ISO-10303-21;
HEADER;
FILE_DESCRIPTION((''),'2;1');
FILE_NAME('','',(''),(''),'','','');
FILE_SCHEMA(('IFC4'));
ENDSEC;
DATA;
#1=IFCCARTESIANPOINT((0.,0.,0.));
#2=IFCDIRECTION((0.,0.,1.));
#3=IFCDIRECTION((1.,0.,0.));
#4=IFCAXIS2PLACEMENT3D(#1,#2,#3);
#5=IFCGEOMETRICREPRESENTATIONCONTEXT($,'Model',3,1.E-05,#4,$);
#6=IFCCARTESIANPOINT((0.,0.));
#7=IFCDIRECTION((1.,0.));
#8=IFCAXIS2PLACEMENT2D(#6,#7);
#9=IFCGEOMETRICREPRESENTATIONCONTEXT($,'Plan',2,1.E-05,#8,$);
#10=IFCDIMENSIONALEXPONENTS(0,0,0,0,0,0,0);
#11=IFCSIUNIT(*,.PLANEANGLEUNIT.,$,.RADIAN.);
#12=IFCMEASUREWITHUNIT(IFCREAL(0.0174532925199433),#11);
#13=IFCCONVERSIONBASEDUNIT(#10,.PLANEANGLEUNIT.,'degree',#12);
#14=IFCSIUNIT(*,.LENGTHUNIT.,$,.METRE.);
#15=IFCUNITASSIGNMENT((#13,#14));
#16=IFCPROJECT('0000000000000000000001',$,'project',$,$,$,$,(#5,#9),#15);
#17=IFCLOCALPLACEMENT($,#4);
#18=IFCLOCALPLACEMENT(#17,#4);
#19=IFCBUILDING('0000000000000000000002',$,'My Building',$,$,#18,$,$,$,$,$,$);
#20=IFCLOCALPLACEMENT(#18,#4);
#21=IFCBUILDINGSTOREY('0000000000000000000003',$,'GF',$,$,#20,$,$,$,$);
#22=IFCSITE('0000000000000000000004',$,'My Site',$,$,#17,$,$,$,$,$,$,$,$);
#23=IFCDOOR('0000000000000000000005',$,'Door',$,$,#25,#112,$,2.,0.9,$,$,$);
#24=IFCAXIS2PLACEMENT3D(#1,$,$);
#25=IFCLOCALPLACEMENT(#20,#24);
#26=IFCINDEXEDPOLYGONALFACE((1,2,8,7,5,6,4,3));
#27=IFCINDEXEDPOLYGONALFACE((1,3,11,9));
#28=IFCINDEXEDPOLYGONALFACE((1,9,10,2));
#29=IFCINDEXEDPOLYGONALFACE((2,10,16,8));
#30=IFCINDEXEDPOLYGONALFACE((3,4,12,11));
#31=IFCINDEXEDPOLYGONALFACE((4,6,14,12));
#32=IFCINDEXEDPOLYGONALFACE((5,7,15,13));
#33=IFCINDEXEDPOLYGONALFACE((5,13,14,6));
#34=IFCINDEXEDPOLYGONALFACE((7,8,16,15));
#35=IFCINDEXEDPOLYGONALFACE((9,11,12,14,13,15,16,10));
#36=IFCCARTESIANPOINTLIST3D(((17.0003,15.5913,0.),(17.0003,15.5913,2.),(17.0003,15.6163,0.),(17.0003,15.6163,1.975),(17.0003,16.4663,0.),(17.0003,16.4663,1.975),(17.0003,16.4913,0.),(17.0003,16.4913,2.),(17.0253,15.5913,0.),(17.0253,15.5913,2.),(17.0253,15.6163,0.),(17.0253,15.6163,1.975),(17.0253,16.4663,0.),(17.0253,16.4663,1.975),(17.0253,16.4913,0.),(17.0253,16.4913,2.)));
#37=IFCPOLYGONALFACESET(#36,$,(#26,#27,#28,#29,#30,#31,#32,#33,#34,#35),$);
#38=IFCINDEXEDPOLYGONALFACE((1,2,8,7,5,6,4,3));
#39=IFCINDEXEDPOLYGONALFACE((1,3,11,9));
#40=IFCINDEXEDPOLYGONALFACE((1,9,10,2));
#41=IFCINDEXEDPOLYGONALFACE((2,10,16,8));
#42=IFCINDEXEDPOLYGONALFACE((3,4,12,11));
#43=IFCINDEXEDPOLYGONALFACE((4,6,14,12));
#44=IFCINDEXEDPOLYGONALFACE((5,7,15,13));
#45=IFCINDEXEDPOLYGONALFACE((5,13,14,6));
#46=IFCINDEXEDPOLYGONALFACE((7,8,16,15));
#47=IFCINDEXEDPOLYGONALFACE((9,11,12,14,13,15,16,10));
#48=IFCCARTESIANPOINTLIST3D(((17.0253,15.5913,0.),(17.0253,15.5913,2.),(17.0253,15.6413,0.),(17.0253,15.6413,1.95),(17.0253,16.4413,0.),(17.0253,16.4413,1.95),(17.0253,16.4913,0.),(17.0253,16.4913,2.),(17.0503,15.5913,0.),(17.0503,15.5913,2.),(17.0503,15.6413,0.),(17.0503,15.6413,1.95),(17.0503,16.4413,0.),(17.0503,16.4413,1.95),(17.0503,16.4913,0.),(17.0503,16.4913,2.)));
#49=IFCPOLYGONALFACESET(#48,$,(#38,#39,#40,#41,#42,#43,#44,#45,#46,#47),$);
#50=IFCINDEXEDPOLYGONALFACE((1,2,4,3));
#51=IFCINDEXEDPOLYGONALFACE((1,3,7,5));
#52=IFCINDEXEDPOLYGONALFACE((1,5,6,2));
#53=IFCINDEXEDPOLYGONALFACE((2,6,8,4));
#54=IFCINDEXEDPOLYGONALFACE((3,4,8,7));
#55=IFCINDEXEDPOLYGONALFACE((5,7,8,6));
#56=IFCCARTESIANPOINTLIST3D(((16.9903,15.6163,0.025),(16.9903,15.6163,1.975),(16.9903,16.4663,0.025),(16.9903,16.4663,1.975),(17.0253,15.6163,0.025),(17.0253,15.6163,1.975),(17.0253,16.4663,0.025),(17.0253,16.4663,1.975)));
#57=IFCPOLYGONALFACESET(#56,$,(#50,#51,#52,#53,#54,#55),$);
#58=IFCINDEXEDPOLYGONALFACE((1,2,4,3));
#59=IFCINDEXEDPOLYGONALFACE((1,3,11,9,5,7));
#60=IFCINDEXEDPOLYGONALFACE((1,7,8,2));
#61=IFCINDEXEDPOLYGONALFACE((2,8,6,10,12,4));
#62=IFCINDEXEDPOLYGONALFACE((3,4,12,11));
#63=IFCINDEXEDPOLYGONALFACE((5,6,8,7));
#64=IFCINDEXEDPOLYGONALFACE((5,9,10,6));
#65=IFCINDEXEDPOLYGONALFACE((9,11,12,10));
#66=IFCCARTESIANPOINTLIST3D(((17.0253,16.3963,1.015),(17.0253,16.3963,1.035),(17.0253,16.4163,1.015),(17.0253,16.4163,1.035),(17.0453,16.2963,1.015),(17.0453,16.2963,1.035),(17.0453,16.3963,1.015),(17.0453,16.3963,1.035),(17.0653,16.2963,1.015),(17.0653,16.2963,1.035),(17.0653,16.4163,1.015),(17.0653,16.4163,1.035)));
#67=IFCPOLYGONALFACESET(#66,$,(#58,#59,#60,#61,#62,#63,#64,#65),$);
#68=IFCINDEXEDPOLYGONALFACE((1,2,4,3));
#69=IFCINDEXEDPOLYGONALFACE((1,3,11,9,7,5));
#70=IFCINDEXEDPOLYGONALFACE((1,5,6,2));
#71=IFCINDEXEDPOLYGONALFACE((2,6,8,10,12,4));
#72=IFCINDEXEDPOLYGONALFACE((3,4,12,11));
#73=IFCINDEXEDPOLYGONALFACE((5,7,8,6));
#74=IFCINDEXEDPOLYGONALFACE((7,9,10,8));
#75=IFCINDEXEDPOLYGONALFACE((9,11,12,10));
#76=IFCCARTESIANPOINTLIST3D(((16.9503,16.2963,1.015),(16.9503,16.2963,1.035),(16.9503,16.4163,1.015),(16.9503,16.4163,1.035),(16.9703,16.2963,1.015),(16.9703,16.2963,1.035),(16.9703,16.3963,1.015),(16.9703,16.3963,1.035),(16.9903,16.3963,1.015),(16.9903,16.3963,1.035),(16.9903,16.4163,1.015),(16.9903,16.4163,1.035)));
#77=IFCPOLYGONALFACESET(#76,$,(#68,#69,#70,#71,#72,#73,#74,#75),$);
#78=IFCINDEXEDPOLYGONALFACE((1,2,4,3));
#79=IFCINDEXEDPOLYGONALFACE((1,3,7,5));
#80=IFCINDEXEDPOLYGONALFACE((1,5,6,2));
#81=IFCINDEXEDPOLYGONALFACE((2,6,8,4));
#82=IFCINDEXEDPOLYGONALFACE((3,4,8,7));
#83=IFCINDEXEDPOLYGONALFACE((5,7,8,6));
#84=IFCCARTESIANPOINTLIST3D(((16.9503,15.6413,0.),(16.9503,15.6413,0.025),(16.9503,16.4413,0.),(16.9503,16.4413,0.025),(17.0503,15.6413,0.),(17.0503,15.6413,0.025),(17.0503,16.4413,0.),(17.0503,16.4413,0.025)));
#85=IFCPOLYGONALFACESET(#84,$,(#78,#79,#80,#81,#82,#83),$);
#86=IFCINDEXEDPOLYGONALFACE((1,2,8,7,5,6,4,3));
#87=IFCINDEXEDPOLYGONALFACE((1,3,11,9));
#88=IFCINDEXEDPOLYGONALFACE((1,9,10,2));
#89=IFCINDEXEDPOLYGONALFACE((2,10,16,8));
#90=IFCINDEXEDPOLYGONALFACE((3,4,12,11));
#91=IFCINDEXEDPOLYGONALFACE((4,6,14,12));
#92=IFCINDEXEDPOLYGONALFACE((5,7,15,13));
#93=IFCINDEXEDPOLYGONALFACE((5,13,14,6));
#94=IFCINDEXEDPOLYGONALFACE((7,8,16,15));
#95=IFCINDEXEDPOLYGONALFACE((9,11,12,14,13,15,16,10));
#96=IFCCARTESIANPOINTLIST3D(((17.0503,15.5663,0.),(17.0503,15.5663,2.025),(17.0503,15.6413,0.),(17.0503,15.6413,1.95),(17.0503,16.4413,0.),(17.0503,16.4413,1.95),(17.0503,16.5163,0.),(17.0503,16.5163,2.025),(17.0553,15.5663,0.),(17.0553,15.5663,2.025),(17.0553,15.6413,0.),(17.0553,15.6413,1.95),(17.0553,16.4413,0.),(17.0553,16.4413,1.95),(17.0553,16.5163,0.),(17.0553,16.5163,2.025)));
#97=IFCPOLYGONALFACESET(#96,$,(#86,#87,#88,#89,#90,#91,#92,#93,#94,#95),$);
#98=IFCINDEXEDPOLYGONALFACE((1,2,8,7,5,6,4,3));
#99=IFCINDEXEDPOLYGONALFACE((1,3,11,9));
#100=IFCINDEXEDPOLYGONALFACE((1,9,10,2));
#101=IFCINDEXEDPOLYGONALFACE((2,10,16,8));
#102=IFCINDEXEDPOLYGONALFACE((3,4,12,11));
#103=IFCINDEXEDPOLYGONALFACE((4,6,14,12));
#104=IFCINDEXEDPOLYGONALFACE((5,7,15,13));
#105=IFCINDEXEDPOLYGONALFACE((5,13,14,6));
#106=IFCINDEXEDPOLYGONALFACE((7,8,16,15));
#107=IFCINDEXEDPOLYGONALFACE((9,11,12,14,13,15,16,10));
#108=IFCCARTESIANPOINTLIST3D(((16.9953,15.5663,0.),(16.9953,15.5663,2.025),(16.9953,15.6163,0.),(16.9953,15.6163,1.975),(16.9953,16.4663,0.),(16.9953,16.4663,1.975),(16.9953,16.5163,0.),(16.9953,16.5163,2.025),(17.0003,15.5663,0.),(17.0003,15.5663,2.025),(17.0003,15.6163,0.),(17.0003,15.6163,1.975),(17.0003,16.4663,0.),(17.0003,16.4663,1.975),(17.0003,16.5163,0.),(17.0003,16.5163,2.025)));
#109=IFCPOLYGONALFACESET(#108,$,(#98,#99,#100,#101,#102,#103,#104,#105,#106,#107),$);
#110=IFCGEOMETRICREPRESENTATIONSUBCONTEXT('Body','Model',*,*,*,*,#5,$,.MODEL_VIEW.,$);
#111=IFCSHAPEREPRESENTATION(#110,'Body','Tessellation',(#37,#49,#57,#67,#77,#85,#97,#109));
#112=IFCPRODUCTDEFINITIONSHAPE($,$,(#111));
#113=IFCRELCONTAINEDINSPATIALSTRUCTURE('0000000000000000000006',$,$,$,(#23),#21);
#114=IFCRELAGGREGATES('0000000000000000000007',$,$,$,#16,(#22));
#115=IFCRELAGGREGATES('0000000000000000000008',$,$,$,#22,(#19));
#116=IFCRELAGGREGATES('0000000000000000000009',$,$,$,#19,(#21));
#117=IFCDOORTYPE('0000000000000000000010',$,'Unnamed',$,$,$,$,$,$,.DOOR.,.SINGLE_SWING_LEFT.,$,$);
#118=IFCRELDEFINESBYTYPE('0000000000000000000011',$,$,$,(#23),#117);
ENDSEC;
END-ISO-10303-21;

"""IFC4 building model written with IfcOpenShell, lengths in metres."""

from ifc_helpers import new_model, entity, si_unit, converted_unit, frame, origin_with_axes, origin_2d_with_axis, place, context, subcontext, project, spatial, line, indexed_curve, outline, extrude, shape, source, transform, mapped, type_object, type_shapes, element, save


model = new_model("IFC4")

# Units and contexts
model_context = context("Model", 3, precision=1e-05, world=origin_with_axes())
plan_context = context("Plan", 2, precision=1e-05, world=origin_2d_with_axis())
body_context_1 = subcontext(model_context, "Body", "Model", "MODEL_VIEW")
body_context_2 = subcontext(plan_context, "Body", "Plan", "PLAN_VIEW")
ifc_project = project(units=[converted_unit("PLANEANGLEUNIT", "degree", entity("IfcReal", 0.0174532925199433), si_unit("PLANEANGLEUNIT", "RADIAN"), dimensions=[0, 0, 0, 0, 0, 0, 0]), si_unit("LENGTHUNIT", "METRE")], contexts=[model_context, plan_context])

# Site, building, storey
site_placement = place(None, origin_with_axes())
site = spatial("IfcSite", under=ifc_project, at=site_placement, Name="My Site")
building_placement = place(site_placement, origin_with_axes())
building = spatial("IfcBuilding", under=site, at=building_placement, Name="My Building")
storey_placement = place(building_placement, origin_with_axes())
storey = spatial("IfcBuildingStorey", under=building, at=storey_placement, Name="GF")

# Shared definitions
door_type = type_object("IfcDoorType", Name="Unnamed", OperationType="SINGLE_SWING_LEFT", PredefinedType="DOOR")
shared_shape_1 = source(origin_with_axes(), body_context_1, "Body", "SweptSolid", [
    extrude(outline(indexed_curve([(0.0, 0.0), (0.0, 2.0), (0.9, 2.0), (0.9, 0.0), (0.875, 0.0), (0.875, 1.975), (0.025, 1.975), (0.025, 0.0)], segments=[line(1, 2, 3, 4, 5, 6, 7, 8, 1)])), frame((0.0, 0.025, 0.0), z_axis=(0.0, -1.0, 0.0), x_axis=(1.0, 0.0, 0.0)), (0.0, 0.0, -1.0), 0.025),
    extrude(outline(indexed_curve([(0.0, 0.0), (0.0, 2.0), (0.9, 2.0), (0.9, 0.0), (0.85, 0.0), (0.85, 1.95), (0.05, 1.95), (0.05, 0.0)], segments=[line(1, 2, 3, 4, 5, 6, 7, 8, 1)])), frame((0.0, 0.0, 0.0), z_axis=(0.0, -1.0, 0.0), x_axis=(1.0, 0.0, 0.0)), (0.0, 0.0, -1.0), 0.025),
    extrude(outline(indexed_curve([(0.0, 0.0), (0.85, 0.0), (0.85, 0.035), (0.0, 0.035)], segments=[line(1, 2, 3, 4, 1)])), frame((0.025, 0.025, 0.025), z_axis=(0.0, 0.0, 1.0), x_axis=(1.0, 0.0, 0.0)), (0.0, 0.0, 1.0), 1.95),
    extrude(outline(indexed_curve([(0.0, 0.0), (0.0, -0.04), (-0.12, -0.04), (-0.12, -0.02), (-0.02, -0.02), (-0.02, 0.0)], segments=[line(1, 2, 3, 4, 5, 6, 1)])), frame((0.825, 0.025, 1.015), z_axis=(0.0, 0.0, 1.0), x_axis=(1.0, 0.0, 0.0)), (0.0, 0.0, 1.0), 0.02),
    extrude(outline(indexed_curve([(0.0, 0.0), (0.0, 0.04), (-0.12, 0.04), (-0.12, 0.02), (-0.02, 0.02), (-0.02, 0.0)], segments=[line(1, 2, 3, 4, 5, 6, 1)])), frame((0.825, 0.06, 1.015), z_axis=(0.0, 0.0, 1.0), x_axis=(1.0, 0.0, 0.0)), (0.0, 0.0, 1.0), 0.02),
    extrude(outline(indexed_curve([(0.0, 0.0), (0.8, 0.0), (0.8, 0.1), (0.0, 0.1)], segments=[line(1, 2, 3, 4, 1)])), frame((0.05, 0.0, 0.0), z_axis=(0.0, 0.0, 1.0), x_axis=(1.0, 0.0, 0.0)), (0.0, 0.0, 1.0), 0.025),
    extrude(outline(indexed_curve([(0.0, 0.0), (0.0, 2.025), (0.95, 2.025), (0.95, 0.0), (0.875, 0.0), (0.875, 1.95), (0.075, 1.95), (0.075, 0.0)], segments=[line(1, 2, 3, 4, 5, 6, 7, 8, 1)])), frame((-0.025, -0.005, 0.0), z_axis=(0.0, -1.0, 0.0), x_axis=(1.0, 0.0, 0.0)), (0.0, 0.0, -1.0), 0.005),
    extrude(outline(indexed_curve([(0.0, 0.0), (0.0, 2.025), (0.95, 2.025), (0.95, 0.0), (0.9, 0.0), (0.9, 1.975), (0.05, 1.975), (0.05, 0.0)], segments=[line(1, 2, 3, 4, 5, 6, 7, 8, 1)])), frame((-0.025, 0.05, 0.0), z_axis=(0.0, -1.0, 0.0), x_axis=(1.0, 0.0, 0.0)), (0.0, 0.0, -1.0), 0.005),
])
shared_shape_2 = source(origin_with_axes(), body_context_2, "Body", "Curve2D", [
    entity("IfcIndexedPolyCurve", entity("IfcCartesianPointList2D", [[0.0, 0.0], [0.0, 0.05], [0.025, 0.05], [0.025, 0.025], [0.05, 0.025], [0.05, 0.0]]), [entity("IfcLineIndex", [1, 2, 3, 4, 5, 6, 1])]),
    entity("IfcIndexedPolyCurve", entity("IfcCartesianPointList2D", [[0.9, 0.0], [0.9, 0.05], [0.875, 0.05], [0.875, 0.025], [0.85, 0.025], [0.85, 0.0]]), [entity("IfcLineIndex", [1, 2, 3, 4, 5, 6, 1])]),
    entity("IfcTrimmedCurve", entity("IfcEllipse", entity("IfcAxis2Placement2D", entity("IfcCartesianPoint", [0.06, 0.05]), entity("IfcDirection", [1.0, 0.0])), 0.815, 0.85), [entity("IfcCartesianPoint", [0.875, 0.05])], [entity("IfcCartesianPoint", [0.06, 0.9])], True, "CARTESIAN"),
    entity("IfcIndexedPolyCurve", entity("IfcCartesianPointList2D", [[0.025, 0.05], [0.06, 0.05], [0.06, 0.9], [0.025, 0.9]]), [entity("IfcLineIndex", [1, 2, 3, 4, 1])]),
])
type_shapes(door_type, [shared_shape_1, shared_shape_2])

# Door
door_1_placement = place(storey_placement, frame((17.0503, 15.5913, 0.0), z_axis=(0.0, 0.0, 1.0), x_axis=(0.0, 1.0, 0.0)))
element("IfcDoor", 1, at=door_1_placement, inside=storey, type_object=door_type, Name="Door", OverallHeight=2.0, OverallWidth=0.9, shapes=[
    shape(body_context_1, "Body", "MappedRepresentation", [mapped(shared_shape_1, transform((0.0, 0.0, 0.0), x_axis=(1.0, 0.0, 0.0), y_axis=(0.0, 1.0, 0.0), z_axis=(0.0, 0.0, 1.0), scale=1.0))]),
    shape(body_context_2, "Body", "MappedRepresentation", [mapped(shared_shape_2, transform((0.0, 0.0, 0.0), x_axis=(1.0, 0.0, 0.0), y_axis=(0.0, 1.0, 0.0), z_axis=(0.0, 0.0, 1.0), scale=1.0))]),
])

save(model, "model.ifc")
